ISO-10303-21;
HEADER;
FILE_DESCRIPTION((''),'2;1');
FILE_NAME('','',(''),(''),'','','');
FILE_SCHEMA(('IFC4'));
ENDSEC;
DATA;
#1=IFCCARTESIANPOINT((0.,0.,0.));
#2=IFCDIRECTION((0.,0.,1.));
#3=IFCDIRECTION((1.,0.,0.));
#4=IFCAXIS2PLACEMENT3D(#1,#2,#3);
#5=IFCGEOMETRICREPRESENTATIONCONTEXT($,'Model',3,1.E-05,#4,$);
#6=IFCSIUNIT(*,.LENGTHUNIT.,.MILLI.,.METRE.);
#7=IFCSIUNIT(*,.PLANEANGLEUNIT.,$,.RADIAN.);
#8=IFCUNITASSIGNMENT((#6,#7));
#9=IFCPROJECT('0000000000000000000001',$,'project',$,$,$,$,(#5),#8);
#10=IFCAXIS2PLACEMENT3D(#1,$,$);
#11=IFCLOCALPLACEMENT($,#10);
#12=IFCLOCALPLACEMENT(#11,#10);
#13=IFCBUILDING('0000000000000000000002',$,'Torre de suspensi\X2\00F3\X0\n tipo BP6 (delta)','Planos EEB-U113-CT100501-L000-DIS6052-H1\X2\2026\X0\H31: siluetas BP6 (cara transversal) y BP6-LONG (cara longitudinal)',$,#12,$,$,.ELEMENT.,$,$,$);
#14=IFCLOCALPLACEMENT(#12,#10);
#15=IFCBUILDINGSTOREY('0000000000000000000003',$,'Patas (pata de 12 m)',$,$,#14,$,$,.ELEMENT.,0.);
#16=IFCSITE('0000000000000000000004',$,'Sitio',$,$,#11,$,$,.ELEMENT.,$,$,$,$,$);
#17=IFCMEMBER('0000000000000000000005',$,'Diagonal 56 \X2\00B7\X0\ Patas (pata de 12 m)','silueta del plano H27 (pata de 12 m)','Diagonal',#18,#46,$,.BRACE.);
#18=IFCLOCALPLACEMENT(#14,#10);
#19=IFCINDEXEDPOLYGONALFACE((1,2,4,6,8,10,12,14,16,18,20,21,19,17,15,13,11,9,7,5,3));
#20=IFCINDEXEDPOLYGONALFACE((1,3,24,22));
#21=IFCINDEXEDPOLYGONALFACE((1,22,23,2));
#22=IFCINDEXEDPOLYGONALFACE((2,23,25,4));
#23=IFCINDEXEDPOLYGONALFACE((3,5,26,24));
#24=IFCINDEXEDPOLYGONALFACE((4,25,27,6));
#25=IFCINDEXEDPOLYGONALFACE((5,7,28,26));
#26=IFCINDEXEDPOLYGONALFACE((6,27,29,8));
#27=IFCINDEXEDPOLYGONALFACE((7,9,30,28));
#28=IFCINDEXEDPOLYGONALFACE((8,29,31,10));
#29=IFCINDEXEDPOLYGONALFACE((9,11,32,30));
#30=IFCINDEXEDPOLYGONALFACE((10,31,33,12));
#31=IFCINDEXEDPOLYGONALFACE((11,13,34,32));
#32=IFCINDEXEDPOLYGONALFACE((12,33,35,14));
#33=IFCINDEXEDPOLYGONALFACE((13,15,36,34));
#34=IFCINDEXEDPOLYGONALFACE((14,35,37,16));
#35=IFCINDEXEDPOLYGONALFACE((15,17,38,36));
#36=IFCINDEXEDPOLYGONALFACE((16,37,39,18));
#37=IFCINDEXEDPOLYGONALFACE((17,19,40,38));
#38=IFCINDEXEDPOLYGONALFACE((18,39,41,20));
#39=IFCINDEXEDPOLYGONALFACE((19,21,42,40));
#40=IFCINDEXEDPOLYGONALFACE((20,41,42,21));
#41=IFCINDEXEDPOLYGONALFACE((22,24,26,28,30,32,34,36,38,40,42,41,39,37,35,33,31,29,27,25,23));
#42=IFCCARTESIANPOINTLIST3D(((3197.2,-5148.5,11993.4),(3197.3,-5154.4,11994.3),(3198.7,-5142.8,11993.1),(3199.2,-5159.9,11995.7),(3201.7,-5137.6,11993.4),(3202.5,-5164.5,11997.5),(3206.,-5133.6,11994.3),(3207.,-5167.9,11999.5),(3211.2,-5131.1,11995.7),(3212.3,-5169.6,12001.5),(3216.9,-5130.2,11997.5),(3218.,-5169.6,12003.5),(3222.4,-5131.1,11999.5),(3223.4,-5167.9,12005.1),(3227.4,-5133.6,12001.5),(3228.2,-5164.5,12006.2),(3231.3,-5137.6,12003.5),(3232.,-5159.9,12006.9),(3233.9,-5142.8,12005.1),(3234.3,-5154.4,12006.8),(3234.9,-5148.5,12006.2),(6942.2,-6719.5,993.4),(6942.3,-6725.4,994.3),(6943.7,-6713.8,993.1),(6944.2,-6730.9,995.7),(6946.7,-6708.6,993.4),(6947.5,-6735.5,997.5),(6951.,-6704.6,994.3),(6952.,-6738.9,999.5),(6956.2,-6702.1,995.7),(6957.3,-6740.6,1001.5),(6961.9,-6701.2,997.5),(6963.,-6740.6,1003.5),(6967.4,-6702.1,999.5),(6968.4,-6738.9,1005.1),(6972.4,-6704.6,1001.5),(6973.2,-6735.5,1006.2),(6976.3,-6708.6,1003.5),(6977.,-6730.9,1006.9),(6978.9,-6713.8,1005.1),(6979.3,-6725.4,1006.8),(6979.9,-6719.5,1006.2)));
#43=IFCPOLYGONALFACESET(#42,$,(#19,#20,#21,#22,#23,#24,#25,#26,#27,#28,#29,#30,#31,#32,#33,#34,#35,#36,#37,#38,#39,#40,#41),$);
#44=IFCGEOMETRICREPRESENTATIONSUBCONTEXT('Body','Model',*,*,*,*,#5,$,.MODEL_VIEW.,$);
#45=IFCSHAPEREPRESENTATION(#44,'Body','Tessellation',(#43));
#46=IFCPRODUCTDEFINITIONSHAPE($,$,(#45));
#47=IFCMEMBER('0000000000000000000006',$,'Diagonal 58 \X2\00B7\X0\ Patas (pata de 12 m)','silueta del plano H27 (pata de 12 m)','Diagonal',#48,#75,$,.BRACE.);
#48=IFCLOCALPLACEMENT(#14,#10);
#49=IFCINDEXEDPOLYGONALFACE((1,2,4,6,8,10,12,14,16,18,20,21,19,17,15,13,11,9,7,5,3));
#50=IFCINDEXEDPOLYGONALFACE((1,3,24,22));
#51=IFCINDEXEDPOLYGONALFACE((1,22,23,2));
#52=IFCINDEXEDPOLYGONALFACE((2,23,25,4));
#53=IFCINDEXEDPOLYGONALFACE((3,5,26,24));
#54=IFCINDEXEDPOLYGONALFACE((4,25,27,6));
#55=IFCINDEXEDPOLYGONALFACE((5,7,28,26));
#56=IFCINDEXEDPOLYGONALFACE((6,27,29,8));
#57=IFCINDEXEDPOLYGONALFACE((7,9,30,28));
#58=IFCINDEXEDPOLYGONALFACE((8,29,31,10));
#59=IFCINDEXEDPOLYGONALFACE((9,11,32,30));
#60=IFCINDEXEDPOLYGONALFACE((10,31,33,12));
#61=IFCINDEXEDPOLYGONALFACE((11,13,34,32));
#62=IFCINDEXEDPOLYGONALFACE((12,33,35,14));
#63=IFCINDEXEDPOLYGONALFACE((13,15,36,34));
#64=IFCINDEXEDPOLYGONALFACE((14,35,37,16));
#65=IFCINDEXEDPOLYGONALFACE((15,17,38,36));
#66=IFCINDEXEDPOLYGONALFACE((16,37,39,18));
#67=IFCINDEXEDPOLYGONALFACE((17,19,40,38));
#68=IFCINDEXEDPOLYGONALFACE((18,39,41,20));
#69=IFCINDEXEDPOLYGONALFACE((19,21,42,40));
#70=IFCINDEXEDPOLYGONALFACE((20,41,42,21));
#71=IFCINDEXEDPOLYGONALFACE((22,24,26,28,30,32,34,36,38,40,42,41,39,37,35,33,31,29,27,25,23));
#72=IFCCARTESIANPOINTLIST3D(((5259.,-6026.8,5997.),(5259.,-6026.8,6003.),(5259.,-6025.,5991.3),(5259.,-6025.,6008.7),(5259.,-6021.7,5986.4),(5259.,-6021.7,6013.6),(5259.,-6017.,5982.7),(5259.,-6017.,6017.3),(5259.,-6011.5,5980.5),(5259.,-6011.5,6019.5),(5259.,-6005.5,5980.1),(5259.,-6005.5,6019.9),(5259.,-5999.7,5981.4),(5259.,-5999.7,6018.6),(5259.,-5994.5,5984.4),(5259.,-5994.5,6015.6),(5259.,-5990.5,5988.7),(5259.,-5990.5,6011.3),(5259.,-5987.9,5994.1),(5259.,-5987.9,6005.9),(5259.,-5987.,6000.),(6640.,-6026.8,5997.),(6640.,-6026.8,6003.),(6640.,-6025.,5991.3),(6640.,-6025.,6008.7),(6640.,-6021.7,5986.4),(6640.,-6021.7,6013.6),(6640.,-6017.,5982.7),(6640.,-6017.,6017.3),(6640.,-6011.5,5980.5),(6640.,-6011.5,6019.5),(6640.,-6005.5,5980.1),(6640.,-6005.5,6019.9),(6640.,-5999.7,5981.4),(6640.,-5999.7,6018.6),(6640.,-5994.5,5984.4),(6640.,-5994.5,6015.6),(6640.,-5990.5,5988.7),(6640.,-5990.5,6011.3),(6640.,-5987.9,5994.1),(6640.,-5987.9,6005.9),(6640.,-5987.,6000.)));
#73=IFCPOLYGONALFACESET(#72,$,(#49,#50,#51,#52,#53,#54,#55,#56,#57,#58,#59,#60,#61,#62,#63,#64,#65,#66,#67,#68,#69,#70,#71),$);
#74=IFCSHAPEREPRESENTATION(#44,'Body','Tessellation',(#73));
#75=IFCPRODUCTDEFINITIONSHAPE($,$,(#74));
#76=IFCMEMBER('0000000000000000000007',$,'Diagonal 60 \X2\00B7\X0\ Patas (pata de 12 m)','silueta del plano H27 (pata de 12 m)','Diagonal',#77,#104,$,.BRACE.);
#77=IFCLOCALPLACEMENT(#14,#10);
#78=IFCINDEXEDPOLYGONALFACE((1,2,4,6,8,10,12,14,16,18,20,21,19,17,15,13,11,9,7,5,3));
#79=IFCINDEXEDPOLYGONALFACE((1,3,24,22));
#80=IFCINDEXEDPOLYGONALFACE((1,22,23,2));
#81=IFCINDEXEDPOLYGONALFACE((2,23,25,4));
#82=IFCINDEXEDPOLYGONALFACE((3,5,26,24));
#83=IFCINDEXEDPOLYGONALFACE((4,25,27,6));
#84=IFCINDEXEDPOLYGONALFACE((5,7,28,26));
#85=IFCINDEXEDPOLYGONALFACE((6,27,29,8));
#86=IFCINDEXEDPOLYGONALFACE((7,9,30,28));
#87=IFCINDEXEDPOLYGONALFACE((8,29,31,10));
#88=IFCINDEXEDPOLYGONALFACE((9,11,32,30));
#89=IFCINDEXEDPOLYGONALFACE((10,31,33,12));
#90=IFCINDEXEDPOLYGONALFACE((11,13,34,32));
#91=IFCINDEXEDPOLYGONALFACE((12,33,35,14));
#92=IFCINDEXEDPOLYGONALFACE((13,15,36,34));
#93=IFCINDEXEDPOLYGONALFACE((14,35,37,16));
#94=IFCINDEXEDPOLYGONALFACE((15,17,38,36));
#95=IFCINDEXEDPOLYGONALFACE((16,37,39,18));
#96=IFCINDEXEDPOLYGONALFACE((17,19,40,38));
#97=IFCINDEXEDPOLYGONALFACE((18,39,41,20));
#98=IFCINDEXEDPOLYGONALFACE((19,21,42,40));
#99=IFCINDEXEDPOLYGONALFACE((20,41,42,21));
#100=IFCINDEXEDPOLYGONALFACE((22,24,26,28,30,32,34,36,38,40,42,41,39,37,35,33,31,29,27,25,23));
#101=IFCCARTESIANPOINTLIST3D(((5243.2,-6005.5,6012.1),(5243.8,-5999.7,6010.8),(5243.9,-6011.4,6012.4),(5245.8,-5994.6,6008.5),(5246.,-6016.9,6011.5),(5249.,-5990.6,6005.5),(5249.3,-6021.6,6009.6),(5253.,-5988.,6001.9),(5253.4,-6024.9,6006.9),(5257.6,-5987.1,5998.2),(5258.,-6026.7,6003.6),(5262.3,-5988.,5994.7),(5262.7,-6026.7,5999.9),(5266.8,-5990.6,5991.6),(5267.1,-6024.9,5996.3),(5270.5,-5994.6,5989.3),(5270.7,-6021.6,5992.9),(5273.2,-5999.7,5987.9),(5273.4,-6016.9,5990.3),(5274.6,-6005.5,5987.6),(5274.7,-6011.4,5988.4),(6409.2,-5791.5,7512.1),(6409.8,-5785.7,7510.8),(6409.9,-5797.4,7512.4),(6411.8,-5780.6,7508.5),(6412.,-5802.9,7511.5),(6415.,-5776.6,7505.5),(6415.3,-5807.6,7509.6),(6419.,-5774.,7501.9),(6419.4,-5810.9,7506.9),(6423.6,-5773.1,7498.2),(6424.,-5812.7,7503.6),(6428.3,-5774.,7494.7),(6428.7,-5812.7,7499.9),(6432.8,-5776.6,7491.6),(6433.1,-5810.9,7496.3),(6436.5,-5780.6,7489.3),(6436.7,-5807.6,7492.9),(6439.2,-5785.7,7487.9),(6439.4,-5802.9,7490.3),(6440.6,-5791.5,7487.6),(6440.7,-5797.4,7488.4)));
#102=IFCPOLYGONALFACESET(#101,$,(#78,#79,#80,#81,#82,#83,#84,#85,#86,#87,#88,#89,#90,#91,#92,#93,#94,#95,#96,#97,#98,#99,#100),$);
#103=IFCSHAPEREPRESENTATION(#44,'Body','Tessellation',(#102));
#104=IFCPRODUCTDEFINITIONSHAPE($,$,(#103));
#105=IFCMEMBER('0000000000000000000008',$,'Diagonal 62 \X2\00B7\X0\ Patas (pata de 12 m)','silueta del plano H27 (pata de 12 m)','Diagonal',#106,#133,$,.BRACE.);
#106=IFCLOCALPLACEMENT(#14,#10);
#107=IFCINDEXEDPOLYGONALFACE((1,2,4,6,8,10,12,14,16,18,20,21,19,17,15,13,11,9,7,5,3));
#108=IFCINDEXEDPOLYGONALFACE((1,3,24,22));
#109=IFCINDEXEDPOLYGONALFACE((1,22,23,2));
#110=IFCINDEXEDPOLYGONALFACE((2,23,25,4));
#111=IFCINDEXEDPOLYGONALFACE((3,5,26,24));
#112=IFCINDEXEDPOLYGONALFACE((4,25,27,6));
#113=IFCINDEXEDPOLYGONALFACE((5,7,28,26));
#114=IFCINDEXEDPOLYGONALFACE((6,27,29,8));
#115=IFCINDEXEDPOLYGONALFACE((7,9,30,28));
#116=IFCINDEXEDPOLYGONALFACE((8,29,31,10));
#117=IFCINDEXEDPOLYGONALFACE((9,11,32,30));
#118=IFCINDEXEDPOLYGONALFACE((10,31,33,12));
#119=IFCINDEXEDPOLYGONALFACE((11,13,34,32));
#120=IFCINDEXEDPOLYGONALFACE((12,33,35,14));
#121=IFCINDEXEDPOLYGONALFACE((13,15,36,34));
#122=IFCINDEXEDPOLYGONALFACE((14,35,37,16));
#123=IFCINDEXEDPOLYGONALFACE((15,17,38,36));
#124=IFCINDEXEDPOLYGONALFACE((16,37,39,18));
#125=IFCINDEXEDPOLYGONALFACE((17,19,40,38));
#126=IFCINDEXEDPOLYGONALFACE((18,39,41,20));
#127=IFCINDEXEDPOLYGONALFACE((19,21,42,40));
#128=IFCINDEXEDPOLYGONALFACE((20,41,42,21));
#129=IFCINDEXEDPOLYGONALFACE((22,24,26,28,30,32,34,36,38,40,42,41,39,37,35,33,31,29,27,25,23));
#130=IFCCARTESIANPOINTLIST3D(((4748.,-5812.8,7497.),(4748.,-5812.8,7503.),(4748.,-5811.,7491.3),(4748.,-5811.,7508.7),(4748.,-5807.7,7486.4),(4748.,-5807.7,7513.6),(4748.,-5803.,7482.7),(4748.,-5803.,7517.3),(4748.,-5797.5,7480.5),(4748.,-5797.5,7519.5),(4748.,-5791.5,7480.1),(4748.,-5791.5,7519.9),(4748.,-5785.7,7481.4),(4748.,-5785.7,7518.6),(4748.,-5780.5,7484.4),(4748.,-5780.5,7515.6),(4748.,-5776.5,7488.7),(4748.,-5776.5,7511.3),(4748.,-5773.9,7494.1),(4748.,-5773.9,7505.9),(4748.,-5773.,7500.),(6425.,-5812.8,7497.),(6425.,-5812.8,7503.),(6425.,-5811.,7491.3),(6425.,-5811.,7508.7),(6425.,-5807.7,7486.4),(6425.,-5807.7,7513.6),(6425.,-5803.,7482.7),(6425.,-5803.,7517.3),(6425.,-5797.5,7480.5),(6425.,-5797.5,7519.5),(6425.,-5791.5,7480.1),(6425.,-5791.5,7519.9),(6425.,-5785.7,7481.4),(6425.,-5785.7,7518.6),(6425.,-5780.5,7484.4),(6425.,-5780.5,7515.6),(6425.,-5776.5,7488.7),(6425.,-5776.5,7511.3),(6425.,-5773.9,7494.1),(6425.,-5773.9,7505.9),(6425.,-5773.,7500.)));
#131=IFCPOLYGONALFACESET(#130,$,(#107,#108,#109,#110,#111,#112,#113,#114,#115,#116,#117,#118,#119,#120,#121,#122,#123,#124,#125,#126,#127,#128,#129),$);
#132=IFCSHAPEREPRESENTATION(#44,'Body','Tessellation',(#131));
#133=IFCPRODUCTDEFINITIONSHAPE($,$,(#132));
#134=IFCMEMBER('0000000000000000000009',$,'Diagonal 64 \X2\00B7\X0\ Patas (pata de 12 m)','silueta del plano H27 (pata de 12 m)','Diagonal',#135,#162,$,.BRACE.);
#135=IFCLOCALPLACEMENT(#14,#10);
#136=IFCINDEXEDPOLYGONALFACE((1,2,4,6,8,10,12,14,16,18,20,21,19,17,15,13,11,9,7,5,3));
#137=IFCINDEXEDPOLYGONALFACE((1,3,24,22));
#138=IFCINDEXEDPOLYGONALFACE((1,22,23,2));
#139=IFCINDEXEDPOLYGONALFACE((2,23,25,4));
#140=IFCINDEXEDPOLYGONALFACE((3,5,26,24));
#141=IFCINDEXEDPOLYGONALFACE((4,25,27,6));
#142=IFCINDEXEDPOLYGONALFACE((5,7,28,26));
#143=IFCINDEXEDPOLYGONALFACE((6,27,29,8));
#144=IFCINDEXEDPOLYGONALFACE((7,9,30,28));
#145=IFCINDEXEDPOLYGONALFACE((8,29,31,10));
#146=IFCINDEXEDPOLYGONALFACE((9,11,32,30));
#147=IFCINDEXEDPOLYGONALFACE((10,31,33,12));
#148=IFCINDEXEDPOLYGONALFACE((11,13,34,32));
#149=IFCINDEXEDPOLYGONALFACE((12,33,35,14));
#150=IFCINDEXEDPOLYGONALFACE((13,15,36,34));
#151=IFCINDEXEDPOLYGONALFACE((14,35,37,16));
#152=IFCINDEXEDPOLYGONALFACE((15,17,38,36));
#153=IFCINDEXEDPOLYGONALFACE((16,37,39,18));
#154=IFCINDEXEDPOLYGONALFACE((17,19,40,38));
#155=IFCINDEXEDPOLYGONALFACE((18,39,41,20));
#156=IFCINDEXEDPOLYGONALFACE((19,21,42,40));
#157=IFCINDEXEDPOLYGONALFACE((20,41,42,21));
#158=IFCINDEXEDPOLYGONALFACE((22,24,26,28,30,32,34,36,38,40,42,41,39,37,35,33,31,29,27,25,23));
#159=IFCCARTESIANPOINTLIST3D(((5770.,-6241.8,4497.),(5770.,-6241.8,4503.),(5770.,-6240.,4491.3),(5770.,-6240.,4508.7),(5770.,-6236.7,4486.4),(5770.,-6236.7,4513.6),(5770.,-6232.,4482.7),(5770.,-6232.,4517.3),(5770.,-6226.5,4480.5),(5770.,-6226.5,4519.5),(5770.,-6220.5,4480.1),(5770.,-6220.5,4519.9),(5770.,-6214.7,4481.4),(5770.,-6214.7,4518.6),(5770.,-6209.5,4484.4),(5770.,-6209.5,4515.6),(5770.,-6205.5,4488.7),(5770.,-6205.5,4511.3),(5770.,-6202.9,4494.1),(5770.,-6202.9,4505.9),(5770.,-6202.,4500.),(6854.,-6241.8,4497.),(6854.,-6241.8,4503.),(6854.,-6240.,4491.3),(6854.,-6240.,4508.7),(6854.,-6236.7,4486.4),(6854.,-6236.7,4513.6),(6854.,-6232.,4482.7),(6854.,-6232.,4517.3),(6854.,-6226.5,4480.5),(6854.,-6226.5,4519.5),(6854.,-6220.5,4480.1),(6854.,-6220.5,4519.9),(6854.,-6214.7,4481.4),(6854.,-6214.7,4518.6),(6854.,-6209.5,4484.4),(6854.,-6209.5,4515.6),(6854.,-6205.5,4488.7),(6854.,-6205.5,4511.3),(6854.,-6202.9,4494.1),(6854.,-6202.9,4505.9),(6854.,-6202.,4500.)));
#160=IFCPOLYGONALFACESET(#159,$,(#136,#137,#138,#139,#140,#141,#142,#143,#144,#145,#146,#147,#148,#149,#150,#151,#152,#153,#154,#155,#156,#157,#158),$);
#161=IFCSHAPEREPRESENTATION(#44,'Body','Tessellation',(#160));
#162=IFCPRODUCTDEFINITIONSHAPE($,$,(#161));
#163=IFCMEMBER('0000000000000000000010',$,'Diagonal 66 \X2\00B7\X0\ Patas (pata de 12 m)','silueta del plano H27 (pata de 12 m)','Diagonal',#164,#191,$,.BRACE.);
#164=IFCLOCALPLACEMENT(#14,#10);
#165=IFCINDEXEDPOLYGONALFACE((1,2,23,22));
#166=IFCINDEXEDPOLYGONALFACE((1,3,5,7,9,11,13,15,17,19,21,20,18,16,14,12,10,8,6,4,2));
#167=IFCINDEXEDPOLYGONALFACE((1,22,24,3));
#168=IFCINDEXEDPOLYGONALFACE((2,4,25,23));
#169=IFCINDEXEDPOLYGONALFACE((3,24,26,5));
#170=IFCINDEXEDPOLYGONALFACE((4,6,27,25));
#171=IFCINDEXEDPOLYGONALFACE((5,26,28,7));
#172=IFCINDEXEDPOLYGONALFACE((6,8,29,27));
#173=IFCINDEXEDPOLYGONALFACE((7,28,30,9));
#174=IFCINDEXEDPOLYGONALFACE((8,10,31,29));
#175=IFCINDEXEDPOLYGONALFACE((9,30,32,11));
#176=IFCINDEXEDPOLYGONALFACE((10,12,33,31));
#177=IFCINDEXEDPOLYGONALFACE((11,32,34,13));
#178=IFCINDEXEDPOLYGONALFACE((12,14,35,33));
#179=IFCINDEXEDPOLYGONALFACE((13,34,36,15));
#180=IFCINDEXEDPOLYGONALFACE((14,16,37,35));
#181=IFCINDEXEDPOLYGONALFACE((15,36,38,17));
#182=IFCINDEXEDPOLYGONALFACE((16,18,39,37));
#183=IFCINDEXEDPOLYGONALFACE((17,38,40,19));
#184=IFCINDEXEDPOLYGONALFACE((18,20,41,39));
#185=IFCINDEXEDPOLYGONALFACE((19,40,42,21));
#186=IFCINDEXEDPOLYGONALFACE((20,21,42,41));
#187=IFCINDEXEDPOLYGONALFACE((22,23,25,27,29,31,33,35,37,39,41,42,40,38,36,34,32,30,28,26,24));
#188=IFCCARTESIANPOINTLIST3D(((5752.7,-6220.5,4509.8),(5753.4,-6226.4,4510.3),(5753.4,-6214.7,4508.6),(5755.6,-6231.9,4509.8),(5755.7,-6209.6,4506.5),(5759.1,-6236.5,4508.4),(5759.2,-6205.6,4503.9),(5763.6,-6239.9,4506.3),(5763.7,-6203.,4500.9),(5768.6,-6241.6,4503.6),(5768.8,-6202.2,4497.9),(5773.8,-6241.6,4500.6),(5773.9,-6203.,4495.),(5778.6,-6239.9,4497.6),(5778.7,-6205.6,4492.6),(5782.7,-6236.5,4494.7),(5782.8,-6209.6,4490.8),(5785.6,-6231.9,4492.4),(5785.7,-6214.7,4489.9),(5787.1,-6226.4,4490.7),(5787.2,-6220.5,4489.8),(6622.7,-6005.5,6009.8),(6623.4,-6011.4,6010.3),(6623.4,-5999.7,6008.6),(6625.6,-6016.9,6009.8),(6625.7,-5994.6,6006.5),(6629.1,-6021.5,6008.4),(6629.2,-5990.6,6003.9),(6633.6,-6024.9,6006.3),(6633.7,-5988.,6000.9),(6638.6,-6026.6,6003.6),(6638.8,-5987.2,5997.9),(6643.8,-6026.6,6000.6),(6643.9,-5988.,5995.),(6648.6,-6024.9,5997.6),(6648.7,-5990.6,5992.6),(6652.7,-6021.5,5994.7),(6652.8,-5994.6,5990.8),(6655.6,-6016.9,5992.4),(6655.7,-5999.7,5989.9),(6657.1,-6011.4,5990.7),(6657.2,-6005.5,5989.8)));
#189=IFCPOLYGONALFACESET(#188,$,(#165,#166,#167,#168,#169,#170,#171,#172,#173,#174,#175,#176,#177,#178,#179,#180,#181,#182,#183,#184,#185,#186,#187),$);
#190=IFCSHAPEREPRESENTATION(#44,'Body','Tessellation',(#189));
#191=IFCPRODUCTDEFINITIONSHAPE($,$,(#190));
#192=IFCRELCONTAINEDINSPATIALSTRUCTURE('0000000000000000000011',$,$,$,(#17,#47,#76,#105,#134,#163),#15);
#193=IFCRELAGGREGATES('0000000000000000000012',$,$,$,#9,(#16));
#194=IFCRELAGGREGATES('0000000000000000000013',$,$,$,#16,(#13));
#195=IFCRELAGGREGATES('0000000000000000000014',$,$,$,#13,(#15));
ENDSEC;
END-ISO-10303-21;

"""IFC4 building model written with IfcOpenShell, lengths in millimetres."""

from ifc_helpers import new_model, si_unit, frame, origin, origin_with_axes, place, context, subcontext, project, spatial, circle, extrude, element, save


model = new_model("IFC4")

# Units and contexts
model_context = context("Model", 3, precision=1e-05, world=origin_with_axes())
body_context = subcontext(model_context, "Body", "Model", "MODEL_VIEW")
ifc_project = project(units=[si_unit("LENGTHUNIT", "METRE", prefix="MILLI"), si_unit("PLANEANGLEUNIT", "RADIAN")], contexts=[model_context])

# Site, building, storey
site_placement = place(None, origin())
site = spatial("IfcSite", under=ifc_project, at=site_placement, Name="Sitio", CompositionType="ELEMENT")
building_placement = place(site_placement, origin())
building = spatial("IfcBuilding", under=site, at=building_placement, Name="Torre de suspensión tipo BP6 (delta)", Description="Planos EEB-U113-CT100501-L000-DIS6052-H1…H31: siluetas BP6 (cara transversal) y BP6-LONG (cara longitudinal)", CompositionType="ELEMENT")
storey_placement = place(building_placement, origin())
storey = spatial("IfcBuildingStorey", under=building, at=storey_placement, Name="Patas (pata de 12 m)", CompositionType="ELEMENT", Elevation=0.0)

# Members
member_1_placement = place(storey_placement, frame((3216.0, -5150.0, 12000.0), z_axis=(0.319383, -0.133979, -0.938107), x_axis=(0.04318, 0.990984, -0.12683)))
element("IfcMember", 1, at=member_1_placement, inside=storey, Name="Diagonal 56 · Patas (pata de 12 m)", Description="silueta del plano H27 (pata de 12 m)", ObjectType="Diagonal", PredefinedType="BRACE", context=body_context, shape_type="SweptSolid", body=[
    extrude(circle(Radius=20.0), None, (0.0, 0.0, 1.0), 11725.7),
])
member_2_placement = place(storey_placement, frame((6640.0, -6007.0, 6000.0), z_axis=(-1.0, 0.0, 0.0), x_axis=(0.0, 1.0, 0.0)))
element("IfcMember", 2, at=member_2_placement, inside=storey, Name="Diagonal 58 · Patas (pata de 12 m)", Description="silueta del plano H27 (pata de 12 m)", ObjectType="Diagonal", PredefinedType="BRACE", context=body_context, shape_type="SweptSolid", body=[
    extrude(circle(Radius=20.0), None, (0.0, 0.0, 1.0), 1381.0),
])
member_3_placement = place(storey_placement, frame((5259.0, -6007.0, 6000.0), z_axis=(0.609865, 0.111931, 0.784561), x_axis=(-0.068694, 0.993716, -0.088372)))
element("IfcMember", 3, at=member_3_placement, inside=storey, Name="Diagonal 60 · Patas (pata de 12 m)", Description="silueta del plano H27 (pata de 12 m)", ObjectType="Diagonal", PredefinedType="BRACE", context=body_context, shape_type="SweptSolid", body=[
    extrude(circle(Radius=20.0), None, (0.0, 0.0, 1.0), 1911.9),
])
member_4_placement = place(storey_placement, frame((6425.0, -5793.0, 7500.0), z_axis=(-1.0, 0.0, 0.0), x_axis=(0.0, 1.0, 0.0)))
element("IfcMember", 4, at=member_4_placement, inside=storey, Name="Diagonal 62 · Patas (pata de 12 m)", Description="silueta del plano H27 (pata de 12 m)", ObjectType="Diagonal", PredefinedType="BRACE", context=body_context, shape_type="SweptSolid", body=[
    extrude(circle(Radius=20.0), None, (0.0, 0.0, 1.0), 1677.0),
])
member_5_placement = place(storey_placement, frame((6854.0, -6222.0, 4500.0), z_axis=(-1.0, 0.0, 0.0), x_axis=(0.0, 1.0, 0.0)))
element("IfcMember", 5, at=member_5_placement, inside=storey, Name="Diagonal 64 · Patas (pata de 12 m)", Description="silueta del plano H27 (pata de 12 m)", ObjectType="Diagonal", PredefinedType="BRACE", context=body_context, shape_type="SweptSolid", body=[
    extrude(circle(Radius=20.0), None, (0.0, 0.0, 1.0), 1084.0),
])
member_6_placement = place(storey_placement, frame((5770.0, -6222.0, 4500.0), z_axis=(0.497906, 0.123046, 0.858458), x_axis=(-0.061734, 0.992401, -0.106438)))
element("IfcMember", 6, at=member_6_placement, inside=storey, Name="Diagonal 66 · Patas (pata de 12 m)", Description="silueta del plano H27 (pata de 12 m)", ObjectType="Diagonal", PredefinedType="BRACE", context=body_context, shape_type="SweptSolid", body=[
    extrude(circle(Radius=20.0), None, (0.0, 0.0, 1.0), 1747.3),
])

save(model, "model.ifc")
